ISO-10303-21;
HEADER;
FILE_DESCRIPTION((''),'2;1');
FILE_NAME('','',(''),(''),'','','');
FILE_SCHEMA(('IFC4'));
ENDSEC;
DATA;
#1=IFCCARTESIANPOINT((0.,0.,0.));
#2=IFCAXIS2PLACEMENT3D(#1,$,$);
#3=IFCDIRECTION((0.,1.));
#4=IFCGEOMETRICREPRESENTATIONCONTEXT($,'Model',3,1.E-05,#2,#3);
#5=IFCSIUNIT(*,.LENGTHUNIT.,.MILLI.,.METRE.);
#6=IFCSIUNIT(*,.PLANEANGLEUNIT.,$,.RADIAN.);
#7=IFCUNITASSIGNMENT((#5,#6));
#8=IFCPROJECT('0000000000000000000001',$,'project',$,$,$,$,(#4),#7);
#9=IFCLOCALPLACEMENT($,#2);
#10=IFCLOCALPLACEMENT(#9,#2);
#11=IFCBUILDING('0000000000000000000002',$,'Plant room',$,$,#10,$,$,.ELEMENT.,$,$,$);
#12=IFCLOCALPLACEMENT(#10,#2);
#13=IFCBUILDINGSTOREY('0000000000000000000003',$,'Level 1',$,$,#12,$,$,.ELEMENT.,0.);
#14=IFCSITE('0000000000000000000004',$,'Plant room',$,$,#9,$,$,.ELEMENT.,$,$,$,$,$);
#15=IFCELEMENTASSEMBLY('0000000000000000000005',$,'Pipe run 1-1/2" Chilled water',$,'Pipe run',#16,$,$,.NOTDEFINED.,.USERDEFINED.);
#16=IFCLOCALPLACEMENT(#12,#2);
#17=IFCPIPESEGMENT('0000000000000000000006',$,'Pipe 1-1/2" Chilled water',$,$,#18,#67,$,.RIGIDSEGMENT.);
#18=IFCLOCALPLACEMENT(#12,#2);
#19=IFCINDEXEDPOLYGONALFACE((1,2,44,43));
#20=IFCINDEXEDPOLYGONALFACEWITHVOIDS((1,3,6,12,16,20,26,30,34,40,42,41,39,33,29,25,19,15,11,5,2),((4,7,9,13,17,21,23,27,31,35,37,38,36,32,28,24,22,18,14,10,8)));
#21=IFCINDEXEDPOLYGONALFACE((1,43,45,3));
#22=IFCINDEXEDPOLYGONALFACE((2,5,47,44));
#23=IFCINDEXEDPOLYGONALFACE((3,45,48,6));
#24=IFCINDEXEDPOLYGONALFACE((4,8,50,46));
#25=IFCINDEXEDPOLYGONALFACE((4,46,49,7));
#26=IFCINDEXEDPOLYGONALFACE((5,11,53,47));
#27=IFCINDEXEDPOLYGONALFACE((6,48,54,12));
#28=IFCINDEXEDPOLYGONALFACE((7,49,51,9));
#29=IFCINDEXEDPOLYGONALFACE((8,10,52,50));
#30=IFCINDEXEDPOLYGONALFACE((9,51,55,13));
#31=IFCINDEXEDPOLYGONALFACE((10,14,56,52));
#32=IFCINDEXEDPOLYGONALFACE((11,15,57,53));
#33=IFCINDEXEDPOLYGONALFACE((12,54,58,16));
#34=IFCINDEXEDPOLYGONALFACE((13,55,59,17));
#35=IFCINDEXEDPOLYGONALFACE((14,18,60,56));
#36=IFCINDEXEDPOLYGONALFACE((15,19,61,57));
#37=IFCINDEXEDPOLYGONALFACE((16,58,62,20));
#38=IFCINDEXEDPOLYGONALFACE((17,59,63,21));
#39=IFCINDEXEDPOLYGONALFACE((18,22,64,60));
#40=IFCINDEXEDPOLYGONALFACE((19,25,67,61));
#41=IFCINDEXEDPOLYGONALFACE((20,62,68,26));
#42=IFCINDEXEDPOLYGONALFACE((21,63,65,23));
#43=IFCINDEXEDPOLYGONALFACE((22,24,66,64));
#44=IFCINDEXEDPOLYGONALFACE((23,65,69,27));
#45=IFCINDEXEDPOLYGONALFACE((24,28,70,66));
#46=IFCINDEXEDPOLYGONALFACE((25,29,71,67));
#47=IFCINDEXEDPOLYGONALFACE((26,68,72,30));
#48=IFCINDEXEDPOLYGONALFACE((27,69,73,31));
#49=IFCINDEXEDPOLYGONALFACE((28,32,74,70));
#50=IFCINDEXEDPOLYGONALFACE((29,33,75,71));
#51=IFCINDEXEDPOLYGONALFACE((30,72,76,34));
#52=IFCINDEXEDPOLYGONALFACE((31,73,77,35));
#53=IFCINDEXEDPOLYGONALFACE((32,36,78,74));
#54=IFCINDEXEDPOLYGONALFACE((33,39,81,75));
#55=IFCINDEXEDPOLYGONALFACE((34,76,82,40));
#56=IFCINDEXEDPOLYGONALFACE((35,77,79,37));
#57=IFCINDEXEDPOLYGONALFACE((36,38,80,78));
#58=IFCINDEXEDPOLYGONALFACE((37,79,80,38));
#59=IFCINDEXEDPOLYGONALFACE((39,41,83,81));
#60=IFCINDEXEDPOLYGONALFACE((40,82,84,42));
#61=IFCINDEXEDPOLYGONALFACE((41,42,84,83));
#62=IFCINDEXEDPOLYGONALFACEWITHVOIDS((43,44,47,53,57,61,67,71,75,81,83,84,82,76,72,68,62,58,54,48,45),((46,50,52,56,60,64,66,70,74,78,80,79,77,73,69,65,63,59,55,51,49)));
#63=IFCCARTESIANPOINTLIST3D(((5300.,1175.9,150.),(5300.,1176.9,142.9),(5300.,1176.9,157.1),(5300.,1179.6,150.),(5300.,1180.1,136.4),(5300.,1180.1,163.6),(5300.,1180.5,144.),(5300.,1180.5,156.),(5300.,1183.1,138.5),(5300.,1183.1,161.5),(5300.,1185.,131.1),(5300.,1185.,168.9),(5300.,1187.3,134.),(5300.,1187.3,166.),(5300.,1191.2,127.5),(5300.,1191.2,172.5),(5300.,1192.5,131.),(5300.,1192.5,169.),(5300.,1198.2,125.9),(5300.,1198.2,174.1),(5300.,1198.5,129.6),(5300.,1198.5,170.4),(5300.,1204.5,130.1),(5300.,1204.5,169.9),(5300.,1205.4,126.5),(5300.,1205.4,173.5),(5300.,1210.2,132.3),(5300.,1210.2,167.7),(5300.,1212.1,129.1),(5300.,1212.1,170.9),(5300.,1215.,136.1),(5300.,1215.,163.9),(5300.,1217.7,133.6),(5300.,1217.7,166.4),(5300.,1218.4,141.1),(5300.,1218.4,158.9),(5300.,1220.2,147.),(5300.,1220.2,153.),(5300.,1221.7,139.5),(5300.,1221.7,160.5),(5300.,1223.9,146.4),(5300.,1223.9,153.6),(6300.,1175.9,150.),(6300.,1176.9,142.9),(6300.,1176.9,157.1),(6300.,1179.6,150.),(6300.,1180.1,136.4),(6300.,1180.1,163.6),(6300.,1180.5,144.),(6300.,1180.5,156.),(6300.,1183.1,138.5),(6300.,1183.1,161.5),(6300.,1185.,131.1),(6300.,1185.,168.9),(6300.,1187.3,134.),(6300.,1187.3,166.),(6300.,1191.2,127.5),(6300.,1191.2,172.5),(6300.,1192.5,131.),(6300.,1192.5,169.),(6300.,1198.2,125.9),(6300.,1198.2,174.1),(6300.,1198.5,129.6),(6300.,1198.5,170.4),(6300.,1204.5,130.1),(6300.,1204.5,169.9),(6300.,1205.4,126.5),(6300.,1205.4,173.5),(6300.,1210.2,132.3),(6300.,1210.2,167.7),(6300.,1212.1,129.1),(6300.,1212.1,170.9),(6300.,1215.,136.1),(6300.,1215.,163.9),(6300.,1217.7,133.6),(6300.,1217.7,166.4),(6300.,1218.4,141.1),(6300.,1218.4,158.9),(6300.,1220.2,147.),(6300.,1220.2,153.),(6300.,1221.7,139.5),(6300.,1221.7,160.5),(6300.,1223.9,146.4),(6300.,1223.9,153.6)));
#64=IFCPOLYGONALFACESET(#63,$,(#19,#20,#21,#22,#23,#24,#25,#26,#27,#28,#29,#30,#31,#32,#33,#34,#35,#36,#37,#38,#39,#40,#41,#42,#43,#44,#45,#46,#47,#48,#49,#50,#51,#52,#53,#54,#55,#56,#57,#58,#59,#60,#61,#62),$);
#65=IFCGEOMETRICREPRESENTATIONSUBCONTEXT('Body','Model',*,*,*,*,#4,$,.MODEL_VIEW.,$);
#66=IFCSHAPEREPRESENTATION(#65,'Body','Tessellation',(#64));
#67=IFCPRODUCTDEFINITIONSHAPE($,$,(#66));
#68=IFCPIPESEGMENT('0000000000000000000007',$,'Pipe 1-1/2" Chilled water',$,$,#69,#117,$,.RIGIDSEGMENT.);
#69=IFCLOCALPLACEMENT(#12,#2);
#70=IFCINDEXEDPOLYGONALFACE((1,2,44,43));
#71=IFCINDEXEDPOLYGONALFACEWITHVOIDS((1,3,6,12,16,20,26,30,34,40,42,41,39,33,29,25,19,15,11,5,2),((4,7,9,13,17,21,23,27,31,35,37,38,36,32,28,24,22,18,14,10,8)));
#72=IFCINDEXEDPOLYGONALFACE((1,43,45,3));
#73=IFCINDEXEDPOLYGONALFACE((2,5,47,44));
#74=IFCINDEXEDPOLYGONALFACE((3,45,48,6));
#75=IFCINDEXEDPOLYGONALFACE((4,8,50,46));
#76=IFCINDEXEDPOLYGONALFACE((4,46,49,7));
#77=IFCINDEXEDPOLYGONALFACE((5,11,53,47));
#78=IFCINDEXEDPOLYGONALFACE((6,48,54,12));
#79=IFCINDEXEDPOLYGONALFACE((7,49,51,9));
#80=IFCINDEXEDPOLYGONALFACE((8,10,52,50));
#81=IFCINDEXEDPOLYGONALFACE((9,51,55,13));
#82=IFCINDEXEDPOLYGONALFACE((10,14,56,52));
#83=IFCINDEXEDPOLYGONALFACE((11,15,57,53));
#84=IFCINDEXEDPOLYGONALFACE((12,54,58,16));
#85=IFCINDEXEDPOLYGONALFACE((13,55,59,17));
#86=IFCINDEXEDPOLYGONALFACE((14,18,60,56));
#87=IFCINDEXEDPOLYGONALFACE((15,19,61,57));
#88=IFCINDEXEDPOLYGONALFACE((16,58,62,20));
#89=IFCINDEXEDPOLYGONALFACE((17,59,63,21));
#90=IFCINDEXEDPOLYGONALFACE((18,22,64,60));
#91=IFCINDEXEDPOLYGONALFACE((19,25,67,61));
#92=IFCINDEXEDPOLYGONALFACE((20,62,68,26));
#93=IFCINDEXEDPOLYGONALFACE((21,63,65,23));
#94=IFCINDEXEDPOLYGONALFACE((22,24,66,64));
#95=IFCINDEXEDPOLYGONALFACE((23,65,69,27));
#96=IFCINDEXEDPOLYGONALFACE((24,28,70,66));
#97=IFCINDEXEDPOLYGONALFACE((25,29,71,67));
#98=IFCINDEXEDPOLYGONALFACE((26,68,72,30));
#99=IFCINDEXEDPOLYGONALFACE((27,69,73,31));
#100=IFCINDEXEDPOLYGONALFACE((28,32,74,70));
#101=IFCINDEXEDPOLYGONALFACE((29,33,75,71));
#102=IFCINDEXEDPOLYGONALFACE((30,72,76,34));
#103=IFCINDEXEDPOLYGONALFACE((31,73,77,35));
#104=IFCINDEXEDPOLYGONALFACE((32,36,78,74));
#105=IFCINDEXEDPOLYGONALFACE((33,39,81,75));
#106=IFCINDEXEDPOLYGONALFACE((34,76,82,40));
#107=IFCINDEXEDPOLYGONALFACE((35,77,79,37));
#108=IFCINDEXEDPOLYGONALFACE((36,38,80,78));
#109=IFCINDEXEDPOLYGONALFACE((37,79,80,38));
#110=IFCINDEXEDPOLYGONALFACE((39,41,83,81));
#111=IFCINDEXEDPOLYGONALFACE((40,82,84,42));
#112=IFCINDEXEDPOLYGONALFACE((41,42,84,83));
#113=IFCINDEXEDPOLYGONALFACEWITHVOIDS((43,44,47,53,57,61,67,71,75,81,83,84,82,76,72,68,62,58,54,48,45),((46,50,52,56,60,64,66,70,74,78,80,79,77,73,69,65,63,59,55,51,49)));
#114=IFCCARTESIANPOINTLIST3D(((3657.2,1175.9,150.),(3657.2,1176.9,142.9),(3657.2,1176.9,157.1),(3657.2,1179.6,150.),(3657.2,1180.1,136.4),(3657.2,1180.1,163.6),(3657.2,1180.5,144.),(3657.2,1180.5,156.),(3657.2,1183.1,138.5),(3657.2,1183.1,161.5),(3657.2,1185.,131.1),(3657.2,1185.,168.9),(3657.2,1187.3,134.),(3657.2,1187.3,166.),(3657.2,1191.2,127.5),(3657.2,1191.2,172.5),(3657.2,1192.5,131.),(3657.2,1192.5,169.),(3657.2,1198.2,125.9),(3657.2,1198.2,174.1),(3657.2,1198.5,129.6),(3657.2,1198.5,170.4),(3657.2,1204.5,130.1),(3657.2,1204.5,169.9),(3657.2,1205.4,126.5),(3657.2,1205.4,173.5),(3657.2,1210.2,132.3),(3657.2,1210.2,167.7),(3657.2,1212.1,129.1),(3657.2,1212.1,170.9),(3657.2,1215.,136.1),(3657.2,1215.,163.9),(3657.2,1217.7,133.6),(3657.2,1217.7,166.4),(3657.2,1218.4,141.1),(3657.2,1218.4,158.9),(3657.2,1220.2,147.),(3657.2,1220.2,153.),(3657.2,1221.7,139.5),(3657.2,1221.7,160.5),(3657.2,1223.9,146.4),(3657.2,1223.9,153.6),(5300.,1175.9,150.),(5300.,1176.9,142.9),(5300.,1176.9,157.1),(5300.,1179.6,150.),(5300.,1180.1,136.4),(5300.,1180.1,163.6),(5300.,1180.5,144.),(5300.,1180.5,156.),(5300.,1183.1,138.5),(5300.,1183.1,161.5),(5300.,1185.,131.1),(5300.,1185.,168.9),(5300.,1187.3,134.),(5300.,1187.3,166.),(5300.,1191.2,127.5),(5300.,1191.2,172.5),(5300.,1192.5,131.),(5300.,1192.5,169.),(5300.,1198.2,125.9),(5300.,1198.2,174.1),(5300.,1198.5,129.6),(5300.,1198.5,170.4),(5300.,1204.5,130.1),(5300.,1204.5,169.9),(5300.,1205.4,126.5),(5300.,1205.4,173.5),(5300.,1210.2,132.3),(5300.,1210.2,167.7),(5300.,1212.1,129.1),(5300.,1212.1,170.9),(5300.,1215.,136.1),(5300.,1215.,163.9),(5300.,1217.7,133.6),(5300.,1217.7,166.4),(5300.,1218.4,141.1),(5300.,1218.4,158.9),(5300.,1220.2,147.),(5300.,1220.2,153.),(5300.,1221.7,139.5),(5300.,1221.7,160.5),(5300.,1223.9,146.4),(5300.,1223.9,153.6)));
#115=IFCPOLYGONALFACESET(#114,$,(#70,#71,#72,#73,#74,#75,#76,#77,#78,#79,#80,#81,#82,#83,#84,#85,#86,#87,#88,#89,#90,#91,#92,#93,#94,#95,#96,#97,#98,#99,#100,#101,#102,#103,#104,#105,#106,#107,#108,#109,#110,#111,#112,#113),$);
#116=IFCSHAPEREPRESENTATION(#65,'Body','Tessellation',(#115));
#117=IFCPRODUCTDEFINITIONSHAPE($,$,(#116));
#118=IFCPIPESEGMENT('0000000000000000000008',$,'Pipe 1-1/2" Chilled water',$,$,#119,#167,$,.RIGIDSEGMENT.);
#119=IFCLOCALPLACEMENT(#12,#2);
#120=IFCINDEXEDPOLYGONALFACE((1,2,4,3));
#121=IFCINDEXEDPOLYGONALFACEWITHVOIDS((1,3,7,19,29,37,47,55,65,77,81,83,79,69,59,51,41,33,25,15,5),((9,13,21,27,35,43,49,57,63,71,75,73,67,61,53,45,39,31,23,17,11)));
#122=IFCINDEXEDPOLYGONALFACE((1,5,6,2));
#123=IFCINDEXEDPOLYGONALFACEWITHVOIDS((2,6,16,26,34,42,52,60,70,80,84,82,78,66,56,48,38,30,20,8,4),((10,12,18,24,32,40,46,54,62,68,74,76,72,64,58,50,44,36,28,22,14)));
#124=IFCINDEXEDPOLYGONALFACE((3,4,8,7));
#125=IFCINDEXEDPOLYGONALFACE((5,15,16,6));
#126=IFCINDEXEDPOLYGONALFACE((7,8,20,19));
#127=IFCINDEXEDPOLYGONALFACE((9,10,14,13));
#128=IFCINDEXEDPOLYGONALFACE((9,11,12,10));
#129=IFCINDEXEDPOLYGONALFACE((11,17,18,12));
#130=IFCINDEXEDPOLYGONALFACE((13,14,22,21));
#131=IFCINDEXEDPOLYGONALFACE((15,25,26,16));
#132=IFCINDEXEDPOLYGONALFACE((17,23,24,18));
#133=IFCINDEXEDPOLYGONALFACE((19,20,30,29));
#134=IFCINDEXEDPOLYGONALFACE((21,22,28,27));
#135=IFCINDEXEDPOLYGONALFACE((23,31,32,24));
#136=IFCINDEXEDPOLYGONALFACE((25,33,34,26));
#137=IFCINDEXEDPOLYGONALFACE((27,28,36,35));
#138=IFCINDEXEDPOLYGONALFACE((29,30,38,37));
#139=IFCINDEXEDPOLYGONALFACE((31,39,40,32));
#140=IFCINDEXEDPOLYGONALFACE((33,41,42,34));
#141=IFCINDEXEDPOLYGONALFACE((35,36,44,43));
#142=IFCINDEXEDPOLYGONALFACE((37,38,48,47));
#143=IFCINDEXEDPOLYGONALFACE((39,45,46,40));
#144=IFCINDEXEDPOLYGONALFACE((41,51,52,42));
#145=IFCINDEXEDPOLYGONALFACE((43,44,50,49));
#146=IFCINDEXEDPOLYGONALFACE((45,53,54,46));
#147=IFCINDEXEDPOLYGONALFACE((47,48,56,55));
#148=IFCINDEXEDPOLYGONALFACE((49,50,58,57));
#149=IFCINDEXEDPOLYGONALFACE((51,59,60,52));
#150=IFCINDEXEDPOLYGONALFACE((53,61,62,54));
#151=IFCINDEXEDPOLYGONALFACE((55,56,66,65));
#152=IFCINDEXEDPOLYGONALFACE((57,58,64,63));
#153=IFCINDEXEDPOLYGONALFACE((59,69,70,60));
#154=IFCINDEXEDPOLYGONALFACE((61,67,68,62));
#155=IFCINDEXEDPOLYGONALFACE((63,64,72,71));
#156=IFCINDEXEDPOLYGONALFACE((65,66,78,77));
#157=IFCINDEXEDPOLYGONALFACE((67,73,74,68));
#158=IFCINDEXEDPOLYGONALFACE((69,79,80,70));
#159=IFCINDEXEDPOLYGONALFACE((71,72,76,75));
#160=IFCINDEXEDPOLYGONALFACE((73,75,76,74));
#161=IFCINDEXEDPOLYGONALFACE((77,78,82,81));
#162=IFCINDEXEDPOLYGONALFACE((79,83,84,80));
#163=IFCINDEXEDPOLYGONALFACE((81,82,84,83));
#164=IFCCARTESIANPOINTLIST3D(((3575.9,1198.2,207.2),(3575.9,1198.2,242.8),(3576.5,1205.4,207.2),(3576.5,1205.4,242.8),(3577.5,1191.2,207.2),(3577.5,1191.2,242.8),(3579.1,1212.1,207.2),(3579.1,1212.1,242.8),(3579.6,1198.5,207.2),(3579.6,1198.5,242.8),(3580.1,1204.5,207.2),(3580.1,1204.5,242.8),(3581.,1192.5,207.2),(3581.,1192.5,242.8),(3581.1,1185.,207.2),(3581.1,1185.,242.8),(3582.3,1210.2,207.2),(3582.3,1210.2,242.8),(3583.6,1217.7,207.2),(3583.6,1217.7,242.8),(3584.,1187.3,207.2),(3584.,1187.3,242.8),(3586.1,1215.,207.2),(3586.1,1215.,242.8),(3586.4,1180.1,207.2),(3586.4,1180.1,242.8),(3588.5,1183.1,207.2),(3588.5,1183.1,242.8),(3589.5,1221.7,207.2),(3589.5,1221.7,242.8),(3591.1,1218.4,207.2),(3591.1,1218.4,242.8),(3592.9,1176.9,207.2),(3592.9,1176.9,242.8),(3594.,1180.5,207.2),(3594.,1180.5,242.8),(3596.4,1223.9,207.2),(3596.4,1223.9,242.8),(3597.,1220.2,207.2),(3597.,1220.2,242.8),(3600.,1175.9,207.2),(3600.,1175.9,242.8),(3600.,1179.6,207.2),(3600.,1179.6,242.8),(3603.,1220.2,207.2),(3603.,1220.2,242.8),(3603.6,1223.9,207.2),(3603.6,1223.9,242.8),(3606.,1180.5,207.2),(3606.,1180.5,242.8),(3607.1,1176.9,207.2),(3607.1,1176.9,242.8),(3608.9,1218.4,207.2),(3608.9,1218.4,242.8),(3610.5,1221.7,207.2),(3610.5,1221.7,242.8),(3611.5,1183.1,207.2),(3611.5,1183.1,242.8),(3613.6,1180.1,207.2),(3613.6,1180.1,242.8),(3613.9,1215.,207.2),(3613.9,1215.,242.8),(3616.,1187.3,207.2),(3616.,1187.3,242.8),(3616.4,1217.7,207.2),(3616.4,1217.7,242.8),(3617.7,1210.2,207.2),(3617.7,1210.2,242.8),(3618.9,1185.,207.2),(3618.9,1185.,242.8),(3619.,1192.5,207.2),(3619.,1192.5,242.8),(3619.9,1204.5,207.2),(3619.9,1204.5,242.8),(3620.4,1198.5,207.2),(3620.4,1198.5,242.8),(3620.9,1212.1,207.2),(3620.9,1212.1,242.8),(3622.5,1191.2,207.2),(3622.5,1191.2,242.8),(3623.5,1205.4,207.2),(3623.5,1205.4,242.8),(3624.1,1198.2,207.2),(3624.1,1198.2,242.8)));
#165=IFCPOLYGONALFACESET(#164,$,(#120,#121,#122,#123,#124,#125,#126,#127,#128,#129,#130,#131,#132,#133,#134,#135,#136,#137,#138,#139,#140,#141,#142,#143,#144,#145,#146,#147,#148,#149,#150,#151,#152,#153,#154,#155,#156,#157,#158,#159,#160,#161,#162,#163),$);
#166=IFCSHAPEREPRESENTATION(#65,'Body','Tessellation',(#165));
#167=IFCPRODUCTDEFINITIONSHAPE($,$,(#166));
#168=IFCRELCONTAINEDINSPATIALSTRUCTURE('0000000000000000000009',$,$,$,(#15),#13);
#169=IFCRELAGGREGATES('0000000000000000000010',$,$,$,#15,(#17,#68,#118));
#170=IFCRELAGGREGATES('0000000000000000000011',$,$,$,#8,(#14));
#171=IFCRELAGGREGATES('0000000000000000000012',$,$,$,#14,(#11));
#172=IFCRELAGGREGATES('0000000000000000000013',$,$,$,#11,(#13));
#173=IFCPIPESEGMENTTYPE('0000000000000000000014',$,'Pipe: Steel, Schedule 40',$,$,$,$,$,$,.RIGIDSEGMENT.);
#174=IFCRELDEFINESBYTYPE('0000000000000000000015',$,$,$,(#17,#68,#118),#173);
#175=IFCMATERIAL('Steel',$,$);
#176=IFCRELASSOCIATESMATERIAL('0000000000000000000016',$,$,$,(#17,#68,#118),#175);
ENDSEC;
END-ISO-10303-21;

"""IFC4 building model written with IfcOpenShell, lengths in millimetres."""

from ifc_helpers import new_model, si_unit, direction, frame, origin, origin_with_axes, origin_2d, place, context, subcontext, project, spatial, hollow_circle, extrude, material, type_object, element, aggregate, save


model = new_model("IFC4")

# Units and contexts
model_context = context("Model", 3, precision=1e-05, world=origin(), true_north=direction((0.0, 1.0)))
body_context = subcontext(model_context, "Body", "Model", "MODEL_VIEW")
ifc_project = project(units=[si_unit("LENGTHUNIT", "METRE", prefix="MILLI"), si_unit("PLANEANGLEUNIT", "RADIAN")], contexts=[model_context])

# Site, building, storey
site_placement = place(None, origin())
site = spatial("IfcSite", under=ifc_project, at=site_placement, Name="Plant room", CompositionType="ELEMENT")
building_placement = place(site_placement, origin())
building = spatial("IfcBuilding", under=site, at=building_placement, Name="Plant room", CompositionType="ELEMENT")
storey_placement = place(building_placement, origin())
storey = spatial("IfcBuildingStorey", under=building, at=storey_placement, Name="Level 1", CompositionType="ELEMENT", Elevation=0.0)

# Element assembly, pipe segments
assembly_1_placement = place(storey_placement, origin_with_axes())
assembly_1 = element("IfcElementAssembly", 1, at=assembly_1_placement, inside=storey, Name="Pipe run 1-1/2\" Chilled water", ObjectType="Pipe run", AssemblyPlace="NOTDEFINED", PredefinedType="USERDEFINED")
ifc_material_1 = material(Name="Steel")
pipe_segment_type = type_object("IfcPipeSegmentType", Name="Pipe: Steel, Schedule 40", PredefinedType="RIGIDSEGMENT")
pipe_segment_1_placement = place(storey_placement, origin_with_axes())
pipe_segment_1 = element("IfcPipeSegment", 2, at=pipe_segment_1_placement, type_object=pipe_segment_type, material=ifc_material_1, Name="Pipe 1-1/2\" Chilled water", PredefinedType="RIGIDSEGMENT", context=body_context, shape_type="SweptSolid", body=[
    extrude(hollow_circle(Radius=24.1, WallThickness=3.7, at=origin_2d()), frame((6300.0, 1200.0, 150.0), z_axis=(-1.0, 0.0, 0.0), x_axis=(0.0, -1.0, 0.0)), (0.0, 0.0, 1.0), 1000.0),
])
pipe_segment_2_placement = place(storey_placement, origin_with_axes())
pipe_segment_2 = element("IfcPipeSegment", 3, at=pipe_segment_2_placement, type_object=pipe_segment_type, material=ifc_material_1, Name="Pipe 1-1/2\" Chilled water", PredefinedType="RIGIDSEGMENT", context=body_context, shape_type="SweptSolid", body=[
    extrude(hollow_circle(Radius=24.1, WallThickness=3.7, at=origin_2d()), frame((5300.0, 1200.0, 150.0), z_axis=(-1.0, 0.0, 0.0), x_axis=(0.0, -1.0, 0.0)), (0.0, 0.0, 1.0), 1642.8),
])
pipe_segment_3_placement = place(storey_placement, origin_with_axes())
pipe_segment_3 = element("IfcPipeSegment", 4, at=pipe_segment_3_placement, type_object=pipe_segment_type, material=ifc_material_1, Name="Pipe 1-1/2\" Chilled water", PredefinedType="RIGIDSEGMENT", context=body_context, shape_type="SweptSolid", body=[
    extrude(hollow_circle(Radius=24.1, WallThickness=3.7, at=origin_2d()), frame((3600.0, 1200.0, 207.2), z_axis=(0.0, 0.0, 1.0), x_axis=(0.0, -1.0, 0.0)), (0.0, 0.0, 1.0), 35.7),
])

aggregate(assembly_1, [pipe_segment_1, pipe_segment_2, pipe_segment_3])

save(model, "model.ifc")
